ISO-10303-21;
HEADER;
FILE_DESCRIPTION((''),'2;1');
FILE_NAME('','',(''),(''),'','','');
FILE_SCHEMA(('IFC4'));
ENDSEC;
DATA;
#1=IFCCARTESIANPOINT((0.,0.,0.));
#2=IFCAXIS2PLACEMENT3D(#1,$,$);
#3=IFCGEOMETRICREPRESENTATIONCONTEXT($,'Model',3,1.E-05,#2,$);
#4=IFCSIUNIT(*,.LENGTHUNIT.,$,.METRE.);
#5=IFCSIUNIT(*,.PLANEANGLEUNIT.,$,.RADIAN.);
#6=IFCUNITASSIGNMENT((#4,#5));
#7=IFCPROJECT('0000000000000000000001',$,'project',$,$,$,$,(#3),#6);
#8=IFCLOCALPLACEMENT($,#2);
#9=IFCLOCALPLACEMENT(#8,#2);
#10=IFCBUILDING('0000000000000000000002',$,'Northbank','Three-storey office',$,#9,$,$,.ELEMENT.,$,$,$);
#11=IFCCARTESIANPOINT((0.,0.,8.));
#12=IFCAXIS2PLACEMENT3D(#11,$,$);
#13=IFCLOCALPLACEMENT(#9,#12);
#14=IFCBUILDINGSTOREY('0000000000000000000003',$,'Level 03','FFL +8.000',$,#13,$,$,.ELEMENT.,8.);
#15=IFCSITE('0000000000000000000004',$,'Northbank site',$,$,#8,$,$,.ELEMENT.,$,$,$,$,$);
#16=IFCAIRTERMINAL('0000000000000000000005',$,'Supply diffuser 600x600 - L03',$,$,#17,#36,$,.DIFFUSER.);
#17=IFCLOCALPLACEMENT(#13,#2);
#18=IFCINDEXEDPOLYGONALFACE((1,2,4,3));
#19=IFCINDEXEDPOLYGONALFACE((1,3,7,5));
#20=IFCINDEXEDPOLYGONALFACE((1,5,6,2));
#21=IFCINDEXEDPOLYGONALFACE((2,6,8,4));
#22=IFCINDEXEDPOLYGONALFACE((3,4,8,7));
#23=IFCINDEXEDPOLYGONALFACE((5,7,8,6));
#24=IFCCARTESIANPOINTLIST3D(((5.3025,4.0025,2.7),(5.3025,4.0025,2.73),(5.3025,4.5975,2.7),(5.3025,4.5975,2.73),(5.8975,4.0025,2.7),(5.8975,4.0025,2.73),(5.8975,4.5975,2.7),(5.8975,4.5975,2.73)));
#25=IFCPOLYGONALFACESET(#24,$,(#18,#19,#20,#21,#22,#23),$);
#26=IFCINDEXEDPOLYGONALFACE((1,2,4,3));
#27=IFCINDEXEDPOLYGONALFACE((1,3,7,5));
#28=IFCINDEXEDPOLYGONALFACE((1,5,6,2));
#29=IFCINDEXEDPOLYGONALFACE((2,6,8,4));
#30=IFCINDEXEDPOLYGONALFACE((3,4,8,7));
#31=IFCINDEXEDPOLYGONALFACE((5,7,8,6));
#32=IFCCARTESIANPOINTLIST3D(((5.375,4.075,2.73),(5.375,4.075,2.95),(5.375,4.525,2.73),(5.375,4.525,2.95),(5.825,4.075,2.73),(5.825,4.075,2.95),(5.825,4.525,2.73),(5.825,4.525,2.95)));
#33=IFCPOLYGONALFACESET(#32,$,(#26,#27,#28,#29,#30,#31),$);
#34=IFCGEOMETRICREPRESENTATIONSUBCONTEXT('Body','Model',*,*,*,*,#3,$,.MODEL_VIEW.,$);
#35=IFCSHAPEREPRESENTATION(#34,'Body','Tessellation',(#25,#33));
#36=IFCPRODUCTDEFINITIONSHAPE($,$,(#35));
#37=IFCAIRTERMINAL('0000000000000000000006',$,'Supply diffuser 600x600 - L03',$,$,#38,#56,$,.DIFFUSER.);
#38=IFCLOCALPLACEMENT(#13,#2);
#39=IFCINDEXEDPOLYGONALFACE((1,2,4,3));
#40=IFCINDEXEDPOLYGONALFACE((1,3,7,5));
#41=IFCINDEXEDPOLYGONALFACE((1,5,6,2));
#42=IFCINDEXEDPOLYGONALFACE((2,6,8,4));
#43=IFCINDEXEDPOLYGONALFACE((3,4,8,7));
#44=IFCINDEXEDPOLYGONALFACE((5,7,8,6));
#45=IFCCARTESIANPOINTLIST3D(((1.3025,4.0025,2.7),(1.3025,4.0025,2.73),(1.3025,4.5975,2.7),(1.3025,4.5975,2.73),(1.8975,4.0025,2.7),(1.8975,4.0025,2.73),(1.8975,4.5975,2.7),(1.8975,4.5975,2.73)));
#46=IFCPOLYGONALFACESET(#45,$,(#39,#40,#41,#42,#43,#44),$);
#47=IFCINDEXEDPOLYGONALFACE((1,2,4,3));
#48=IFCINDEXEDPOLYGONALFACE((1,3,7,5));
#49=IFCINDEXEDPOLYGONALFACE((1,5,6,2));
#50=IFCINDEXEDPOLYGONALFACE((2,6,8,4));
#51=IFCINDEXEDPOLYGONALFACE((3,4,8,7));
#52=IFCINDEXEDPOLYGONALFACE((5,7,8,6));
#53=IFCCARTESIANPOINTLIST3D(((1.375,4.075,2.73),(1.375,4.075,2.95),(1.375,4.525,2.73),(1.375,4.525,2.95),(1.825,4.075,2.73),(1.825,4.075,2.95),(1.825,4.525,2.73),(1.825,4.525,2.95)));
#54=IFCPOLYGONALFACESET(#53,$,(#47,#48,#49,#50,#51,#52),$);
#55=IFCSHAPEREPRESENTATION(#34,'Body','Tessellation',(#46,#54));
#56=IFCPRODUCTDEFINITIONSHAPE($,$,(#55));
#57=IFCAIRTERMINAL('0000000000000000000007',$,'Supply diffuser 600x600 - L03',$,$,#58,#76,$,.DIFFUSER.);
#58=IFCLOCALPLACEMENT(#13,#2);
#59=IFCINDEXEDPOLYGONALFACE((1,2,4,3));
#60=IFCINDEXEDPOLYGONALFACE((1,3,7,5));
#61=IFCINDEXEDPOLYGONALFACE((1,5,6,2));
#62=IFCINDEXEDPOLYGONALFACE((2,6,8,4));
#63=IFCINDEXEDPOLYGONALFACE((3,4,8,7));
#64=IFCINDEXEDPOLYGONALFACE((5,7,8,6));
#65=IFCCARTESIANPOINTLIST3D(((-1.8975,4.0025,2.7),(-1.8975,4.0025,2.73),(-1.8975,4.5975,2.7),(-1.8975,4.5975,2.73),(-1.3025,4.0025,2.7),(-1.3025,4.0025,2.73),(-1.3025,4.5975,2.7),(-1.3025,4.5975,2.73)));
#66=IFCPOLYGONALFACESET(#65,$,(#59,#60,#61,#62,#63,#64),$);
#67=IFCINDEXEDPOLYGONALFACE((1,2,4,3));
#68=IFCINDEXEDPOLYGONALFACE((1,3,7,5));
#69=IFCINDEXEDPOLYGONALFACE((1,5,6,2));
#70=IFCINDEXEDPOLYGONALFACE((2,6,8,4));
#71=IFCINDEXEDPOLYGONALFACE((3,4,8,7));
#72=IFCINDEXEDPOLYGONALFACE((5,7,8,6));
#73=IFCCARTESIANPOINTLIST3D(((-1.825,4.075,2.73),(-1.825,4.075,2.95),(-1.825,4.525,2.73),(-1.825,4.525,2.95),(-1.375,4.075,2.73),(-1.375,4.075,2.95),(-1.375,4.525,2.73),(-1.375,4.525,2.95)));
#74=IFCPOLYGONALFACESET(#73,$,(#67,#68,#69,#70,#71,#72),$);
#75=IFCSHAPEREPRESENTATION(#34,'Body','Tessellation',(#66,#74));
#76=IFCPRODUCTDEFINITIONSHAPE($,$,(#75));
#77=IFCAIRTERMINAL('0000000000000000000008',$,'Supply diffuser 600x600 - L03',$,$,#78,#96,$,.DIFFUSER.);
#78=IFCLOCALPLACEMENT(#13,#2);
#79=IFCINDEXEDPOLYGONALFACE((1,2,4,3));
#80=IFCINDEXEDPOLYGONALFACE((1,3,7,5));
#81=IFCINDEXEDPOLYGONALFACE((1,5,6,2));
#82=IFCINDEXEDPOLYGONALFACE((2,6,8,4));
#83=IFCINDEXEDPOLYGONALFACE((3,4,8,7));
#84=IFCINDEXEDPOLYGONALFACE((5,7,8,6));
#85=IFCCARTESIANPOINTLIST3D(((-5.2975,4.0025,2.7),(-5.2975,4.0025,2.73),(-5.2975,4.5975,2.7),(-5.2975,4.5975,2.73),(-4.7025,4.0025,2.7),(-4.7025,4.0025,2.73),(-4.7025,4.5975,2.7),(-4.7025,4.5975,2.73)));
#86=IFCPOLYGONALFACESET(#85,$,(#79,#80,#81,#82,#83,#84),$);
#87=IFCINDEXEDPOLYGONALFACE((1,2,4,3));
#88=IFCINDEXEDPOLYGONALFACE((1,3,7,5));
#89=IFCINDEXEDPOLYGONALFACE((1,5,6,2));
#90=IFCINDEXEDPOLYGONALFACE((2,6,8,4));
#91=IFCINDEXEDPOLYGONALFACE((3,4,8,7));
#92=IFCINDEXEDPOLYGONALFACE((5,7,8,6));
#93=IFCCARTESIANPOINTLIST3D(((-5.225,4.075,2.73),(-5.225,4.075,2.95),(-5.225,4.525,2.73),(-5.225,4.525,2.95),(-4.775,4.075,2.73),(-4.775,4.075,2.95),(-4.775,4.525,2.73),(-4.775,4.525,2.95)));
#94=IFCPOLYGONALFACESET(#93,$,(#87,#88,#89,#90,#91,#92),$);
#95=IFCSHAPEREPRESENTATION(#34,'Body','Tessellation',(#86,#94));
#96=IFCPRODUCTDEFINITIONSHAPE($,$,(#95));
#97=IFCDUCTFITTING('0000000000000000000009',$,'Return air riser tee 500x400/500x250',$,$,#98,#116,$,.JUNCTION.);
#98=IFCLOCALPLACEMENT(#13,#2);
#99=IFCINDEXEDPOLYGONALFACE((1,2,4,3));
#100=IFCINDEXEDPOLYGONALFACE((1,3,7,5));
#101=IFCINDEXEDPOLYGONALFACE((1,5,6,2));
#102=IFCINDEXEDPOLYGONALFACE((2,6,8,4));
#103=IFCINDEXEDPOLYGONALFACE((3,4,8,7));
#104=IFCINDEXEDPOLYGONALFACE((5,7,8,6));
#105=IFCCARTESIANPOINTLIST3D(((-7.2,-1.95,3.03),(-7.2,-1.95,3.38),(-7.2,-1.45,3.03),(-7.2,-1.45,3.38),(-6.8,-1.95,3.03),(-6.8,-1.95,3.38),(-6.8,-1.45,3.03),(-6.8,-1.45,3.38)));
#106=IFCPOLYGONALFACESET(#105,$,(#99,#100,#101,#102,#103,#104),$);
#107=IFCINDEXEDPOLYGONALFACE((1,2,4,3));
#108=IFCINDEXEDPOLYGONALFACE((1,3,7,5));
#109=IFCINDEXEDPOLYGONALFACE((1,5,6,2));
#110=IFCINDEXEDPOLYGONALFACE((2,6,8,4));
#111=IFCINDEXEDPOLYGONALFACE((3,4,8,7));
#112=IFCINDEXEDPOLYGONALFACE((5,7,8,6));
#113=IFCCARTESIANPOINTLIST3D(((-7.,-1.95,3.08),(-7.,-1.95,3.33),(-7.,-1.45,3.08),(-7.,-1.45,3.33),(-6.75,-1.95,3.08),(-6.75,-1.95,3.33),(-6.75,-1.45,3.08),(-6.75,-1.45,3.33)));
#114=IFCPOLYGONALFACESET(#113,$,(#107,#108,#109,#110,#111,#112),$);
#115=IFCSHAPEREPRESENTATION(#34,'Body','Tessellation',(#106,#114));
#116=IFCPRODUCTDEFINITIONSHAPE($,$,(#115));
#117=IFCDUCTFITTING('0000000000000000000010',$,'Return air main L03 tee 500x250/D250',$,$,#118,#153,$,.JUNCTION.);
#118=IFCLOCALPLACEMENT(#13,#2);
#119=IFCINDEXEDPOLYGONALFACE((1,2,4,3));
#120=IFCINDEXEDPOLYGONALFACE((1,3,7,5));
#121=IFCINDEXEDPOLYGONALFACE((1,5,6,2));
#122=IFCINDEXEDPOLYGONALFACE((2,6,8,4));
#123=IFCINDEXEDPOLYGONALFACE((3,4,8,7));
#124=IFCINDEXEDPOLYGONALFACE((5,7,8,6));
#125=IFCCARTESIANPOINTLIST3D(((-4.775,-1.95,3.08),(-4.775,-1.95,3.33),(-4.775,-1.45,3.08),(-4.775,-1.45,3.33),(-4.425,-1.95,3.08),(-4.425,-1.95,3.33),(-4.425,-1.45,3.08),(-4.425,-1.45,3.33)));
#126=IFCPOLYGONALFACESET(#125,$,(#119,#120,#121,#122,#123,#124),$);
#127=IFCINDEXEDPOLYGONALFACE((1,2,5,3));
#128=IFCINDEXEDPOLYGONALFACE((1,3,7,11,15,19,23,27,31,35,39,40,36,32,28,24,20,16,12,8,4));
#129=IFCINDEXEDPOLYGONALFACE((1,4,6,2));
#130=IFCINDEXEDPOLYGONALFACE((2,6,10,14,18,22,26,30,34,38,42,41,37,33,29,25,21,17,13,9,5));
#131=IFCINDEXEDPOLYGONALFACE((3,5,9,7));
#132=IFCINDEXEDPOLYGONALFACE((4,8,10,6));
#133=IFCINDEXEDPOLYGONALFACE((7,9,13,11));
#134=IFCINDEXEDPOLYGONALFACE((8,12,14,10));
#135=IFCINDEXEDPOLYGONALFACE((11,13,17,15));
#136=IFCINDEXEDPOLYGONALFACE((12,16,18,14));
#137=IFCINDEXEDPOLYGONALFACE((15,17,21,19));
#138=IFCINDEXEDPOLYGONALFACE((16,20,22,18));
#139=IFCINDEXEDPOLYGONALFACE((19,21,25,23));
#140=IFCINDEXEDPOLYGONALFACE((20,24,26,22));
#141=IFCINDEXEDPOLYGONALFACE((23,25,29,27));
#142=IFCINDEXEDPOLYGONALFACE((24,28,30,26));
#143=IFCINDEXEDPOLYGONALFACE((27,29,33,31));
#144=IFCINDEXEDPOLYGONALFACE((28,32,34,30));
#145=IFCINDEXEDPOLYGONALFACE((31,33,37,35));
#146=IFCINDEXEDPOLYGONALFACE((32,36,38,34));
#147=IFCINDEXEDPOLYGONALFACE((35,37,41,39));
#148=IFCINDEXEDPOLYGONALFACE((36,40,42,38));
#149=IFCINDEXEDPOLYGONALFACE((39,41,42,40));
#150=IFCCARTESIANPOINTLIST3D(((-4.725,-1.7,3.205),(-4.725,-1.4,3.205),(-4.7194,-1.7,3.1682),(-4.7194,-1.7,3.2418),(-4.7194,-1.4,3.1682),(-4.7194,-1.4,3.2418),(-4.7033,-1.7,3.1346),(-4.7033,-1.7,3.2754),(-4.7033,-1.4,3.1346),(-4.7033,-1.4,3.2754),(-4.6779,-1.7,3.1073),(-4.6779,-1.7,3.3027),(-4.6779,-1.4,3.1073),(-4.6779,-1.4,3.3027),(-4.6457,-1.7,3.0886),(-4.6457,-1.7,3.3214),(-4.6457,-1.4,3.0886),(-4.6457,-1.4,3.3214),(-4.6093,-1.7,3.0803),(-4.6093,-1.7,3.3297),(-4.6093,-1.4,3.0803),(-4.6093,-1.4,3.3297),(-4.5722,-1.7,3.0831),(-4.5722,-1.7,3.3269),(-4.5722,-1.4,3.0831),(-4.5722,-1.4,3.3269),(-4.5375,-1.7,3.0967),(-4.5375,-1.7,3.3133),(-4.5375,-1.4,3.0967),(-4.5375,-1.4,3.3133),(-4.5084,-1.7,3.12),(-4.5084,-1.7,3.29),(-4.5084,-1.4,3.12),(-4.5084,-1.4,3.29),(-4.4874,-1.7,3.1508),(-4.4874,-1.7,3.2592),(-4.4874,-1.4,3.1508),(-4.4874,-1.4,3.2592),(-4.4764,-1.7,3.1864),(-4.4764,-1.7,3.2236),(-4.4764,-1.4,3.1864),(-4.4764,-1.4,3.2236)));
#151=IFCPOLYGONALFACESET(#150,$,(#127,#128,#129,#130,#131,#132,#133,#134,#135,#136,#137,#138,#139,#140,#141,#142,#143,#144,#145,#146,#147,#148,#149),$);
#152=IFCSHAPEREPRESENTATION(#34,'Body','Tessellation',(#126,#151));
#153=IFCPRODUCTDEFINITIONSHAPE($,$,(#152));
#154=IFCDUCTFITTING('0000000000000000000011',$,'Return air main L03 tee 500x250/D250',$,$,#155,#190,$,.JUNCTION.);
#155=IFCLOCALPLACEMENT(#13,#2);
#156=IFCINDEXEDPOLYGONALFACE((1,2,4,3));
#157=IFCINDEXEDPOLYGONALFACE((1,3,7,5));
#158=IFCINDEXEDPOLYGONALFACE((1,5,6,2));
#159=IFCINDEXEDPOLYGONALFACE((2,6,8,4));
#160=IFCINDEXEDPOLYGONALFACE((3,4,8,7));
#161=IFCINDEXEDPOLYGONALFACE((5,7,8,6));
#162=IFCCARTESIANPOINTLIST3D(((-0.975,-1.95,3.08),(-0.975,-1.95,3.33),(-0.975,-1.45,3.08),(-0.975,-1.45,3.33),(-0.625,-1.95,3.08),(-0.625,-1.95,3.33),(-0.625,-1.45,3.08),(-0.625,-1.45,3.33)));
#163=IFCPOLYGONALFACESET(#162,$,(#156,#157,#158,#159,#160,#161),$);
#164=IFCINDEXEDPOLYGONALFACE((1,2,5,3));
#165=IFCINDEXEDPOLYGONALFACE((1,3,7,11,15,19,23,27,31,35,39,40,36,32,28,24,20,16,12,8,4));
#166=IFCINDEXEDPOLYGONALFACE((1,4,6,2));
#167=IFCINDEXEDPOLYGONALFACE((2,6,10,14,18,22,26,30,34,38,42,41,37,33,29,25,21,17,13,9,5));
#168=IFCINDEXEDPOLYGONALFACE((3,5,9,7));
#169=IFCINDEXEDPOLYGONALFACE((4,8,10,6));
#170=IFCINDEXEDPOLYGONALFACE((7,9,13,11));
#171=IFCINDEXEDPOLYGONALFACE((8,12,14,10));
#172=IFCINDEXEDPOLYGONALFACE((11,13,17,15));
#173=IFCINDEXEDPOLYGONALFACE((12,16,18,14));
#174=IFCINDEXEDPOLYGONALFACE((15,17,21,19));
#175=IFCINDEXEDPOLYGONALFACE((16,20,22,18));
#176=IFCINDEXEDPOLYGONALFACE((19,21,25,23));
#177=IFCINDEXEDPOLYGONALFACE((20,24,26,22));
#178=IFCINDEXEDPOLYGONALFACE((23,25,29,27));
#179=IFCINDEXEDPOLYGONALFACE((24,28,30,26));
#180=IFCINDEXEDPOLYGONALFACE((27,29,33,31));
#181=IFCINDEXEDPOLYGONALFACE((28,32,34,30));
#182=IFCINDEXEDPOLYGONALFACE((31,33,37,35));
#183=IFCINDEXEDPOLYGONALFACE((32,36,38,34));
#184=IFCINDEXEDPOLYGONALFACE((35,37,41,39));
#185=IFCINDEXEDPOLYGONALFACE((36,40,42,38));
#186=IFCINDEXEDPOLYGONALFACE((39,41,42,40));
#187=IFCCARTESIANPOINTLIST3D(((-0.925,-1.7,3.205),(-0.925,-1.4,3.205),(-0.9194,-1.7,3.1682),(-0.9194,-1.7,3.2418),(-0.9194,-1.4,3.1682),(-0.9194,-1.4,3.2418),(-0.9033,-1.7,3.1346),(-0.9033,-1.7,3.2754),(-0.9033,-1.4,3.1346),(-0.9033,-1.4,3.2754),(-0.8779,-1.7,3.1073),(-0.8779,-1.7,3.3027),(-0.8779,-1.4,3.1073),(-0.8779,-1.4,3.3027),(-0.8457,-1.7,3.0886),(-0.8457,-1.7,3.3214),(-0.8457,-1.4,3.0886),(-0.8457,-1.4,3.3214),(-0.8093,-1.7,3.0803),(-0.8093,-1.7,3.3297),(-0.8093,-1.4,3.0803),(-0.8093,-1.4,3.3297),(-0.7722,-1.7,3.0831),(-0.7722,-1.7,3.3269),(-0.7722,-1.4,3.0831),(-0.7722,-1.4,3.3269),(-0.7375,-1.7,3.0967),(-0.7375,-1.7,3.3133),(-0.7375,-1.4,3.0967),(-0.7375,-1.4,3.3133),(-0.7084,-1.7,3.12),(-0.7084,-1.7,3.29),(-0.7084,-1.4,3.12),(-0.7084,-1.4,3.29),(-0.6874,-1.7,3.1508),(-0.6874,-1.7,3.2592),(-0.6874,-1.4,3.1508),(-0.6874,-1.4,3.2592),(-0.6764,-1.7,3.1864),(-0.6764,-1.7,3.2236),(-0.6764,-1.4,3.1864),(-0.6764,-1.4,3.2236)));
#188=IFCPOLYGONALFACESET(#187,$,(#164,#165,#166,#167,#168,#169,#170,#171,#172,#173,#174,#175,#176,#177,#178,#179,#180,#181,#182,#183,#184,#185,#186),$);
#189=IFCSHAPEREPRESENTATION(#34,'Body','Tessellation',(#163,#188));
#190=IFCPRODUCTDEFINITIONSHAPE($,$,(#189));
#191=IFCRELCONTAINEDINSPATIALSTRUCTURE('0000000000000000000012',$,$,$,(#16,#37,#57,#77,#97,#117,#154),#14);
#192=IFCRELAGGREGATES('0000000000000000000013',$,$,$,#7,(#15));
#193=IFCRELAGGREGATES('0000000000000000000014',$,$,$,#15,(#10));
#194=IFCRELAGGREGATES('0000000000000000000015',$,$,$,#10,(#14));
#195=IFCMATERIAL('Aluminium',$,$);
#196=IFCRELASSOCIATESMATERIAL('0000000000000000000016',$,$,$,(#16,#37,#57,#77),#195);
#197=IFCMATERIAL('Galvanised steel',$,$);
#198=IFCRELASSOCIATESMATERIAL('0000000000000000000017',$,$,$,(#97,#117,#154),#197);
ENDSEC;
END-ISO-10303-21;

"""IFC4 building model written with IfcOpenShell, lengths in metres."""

from ifc_helpers import new_model, si_unit, frame, origin, place, context, subcontext, project, spatial, rectangle, circle, extrude, material, element, save


model = new_model("IFC4")

# Units and contexts
model_context = context("Model", 3, precision=1e-05, world=origin())
body_context = subcontext(model_context, "Body", "Model", "MODEL_VIEW")
ifc_project = project(units=[si_unit("LENGTHUNIT", "METRE"), si_unit("PLANEANGLEUNIT", "RADIAN")], contexts=[model_context])

# Site, building, storey
site_placement = place(None, origin())
site = spatial("IfcSite", under=ifc_project, at=site_placement, Name="Northbank site", CompositionType="ELEMENT")
building_placement = place(site_placement, origin())
building = spatial("IfcBuilding", under=site, at=building_placement, Name="Northbank", Description="Three-storey office", CompositionType="ELEMENT")
storey_placement = place(building_placement, frame((0.0, 0.0, 8.0)))
storey = spatial("IfcBuildingStorey", under=building, at=storey_placement, Name="Level 03", Description="FFL +8.000", CompositionType="ELEMENT", Elevation=8.0)

# Air terminal
ifc_material_1 = material(Name="Aluminium")
air_terminal_1_placement = place(storey_placement, frame((0.0, 0.0, -8.0)))
element("IfcAirTerminal", 1, at=air_terminal_1_placement, inside=storey, material=ifc_material_1, Name="Supply diffuser 600x600 - L03", PredefinedType="DIFFUSER", context=body_context, shape_type="SweptSolid", body=[
    extrude(rectangle(XDim=0.595, YDim=0.595), frame((5.6, 4.3, 10.7)), (0.0, 0.0, 1.0), 0.03),
    extrude(rectangle(XDim=0.45, YDim=0.45), frame((5.6, 4.3, 10.73)), (0.0, 0.0, 1.0), 0.22),
])

# Shared definitions
ifc_material_2 = material(Name="Galvanised steel")

# Air terminal
air_terminal_2_placement = place(storey_placement, frame((0.0, 0.0, -8.0)))
element("IfcAirTerminal", 2, at=air_terminal_2_placement, inside=storey, material=ifc_material_1, Name="Supply diffuser 600x600 - L03", PredefinedType="DIFFUSER", context=body_context, shape_type="SweptSolid", body=[
    extrude(rectangle(XDim=0.595, YDim=0.595), frame((1.6, 4.3, 10.7)), (0.0, 0.0, 1.0), 0.03),
    extrude(rectangle(XDim=0.45, YDim=0.45), frame((1.6, 4.3, 10.73)), (0.0, 0.0, 1.0), 0.22),
])

# Air terminal
air_terminal_3_placement = place(storey_placement, frame((0.0, 0.0, -8.0)))
element("IfcAirTerminal", 3, at=air_terminal_3_placement, inside=storey, material=ifc_material_1, Name="Supply diffuser 600x600 - L03", PredefinedType="DIFFUSER", context=body_context, shape_type="SweptSolid", body=[
    extrude(rectangle(XDim=0.595, YDim=0.595), frame((-1.6, 4.3, 10.7)), (0.0, 0.0, 1.0), 0.03),
    extrude(rectangle(XDim=0.45, YDim=0.45), frame((-1.6, 4.3, 10.73)), (0.0, 0.0, 1.0), 0.22),
])

# Air terminal
air_terminal_4_placement = place(storey_placement, frame((0.0, 0.0, -8.0)))
element("IfcAirTerminal", 4, at=air_terminal_4_placement, inside=storey, material=ifc_material_1, Name="Supply diffuser 600x600 - L03", PredefinedType="DIFFUSER", context=body_context, shape_type="SweptSolid", body=[
    extrude(rectangle(XDim=0.595, YDim=0.595), frame((-5.0, 4.3, 10.7)), (0.0, 0.0, 1.0), 0.03),
    extrude(rectangle(XDim=0.45, YDim=0.45), frame((-5.0, 4.3, 10.73)), (0.0, 0.0, 1.0), 0.22),
])

# Duct fitting
duct_fitting_1_placement = place(storey_placement, frame((0.0, 0.0, -8.0)))
element("IfcDuctFitting", 5, at=duct_fitting_1_placement, inside=storey, material=ifc_material_2, Name="Return air riser tee 500x400/500x250", PredefinedType="JUNCTION", context=body_context, shape_type="SweptSolid", body=[
    extrude(rectangle(XDim=0.5, YDim=0.4), frame((-7.0, -1.7, 11.38), z_axis=(0.0, 0.0, -1.0), x_axis=(0.0, -1.0, 0.0)), (0.0, 0.0, 1.0), 0.35),
    extrude(rectangle(XDim=0.5, YDim=0.25), frame((-7.0, -1.7, 11.205), z_axis=(1.0, 0.0, 0.0), x_axis=(0.0, 1.0, 0.0)), (0.0, 0.0, 1.0), 0.25),
])

# Duct fitting
duct_fitting_2_placement = place(storey_placement, frame((0.0, 0.0, -8.0)))
element("IfcDuctFitting", 6, at=duct_fitting_2_placement, inside=storey, material=ifc_material_2, Name="Return air main L03 tee 500x250/D250", PredefinedType="JUNCTION", context=body_context, shape_type="SweptSolid", body=[
    extrude(rectangle(XDim=0.5, YDim=0.25), frame((-4.775, -1.7, 11.205), z_axis=(1.0, 0.0, 0.0), x_axis=(0.0, 1.0, 0.0)), (0.0, 0.0, 1.0), 0.35),
    extrude(circle(Radius=0.125), frame((-4.6, -1.7, 11.205), z_axis=(0.0, 1.0, 0.0), x_axis=(-1.0, 0.0, 0.0)), (0.0, 0.0, 1.0), 0.3),
])

# Duct fitting
duct_fitting_3_placement = place(storey_placement, frame((0.0, 0.0, -8.0)))
element("IfcDuctFitting", 7, at=duct_fitting_3_placement, inside=storey, material=ifc_material_2, Name="Return air main L03 tee 500x250/D250", PredefinedType="JUNCTION", context=body_context, shape_type="SweptSolid", body=[
    extrude(rectangle(XDim=0.5, YDim=0.25), frame((-0.975, -1.7, 11.205), z_axis=(1.0, 0.0, 0.0), x_axis=(0.0, 1.0, 0.0)), (0.0, 0.0, 1.0), 0.35),
    extrude(circle(Radius=0.125), frame((-0.8, -1.7, 11.205), z_axis=(0.0, 1.0, 0.0), x_axis=(-1.0, 0.0, 0.0)), (0.0, 0.0, 1.0), 0.3),
])

save(model, "model.ifc")
